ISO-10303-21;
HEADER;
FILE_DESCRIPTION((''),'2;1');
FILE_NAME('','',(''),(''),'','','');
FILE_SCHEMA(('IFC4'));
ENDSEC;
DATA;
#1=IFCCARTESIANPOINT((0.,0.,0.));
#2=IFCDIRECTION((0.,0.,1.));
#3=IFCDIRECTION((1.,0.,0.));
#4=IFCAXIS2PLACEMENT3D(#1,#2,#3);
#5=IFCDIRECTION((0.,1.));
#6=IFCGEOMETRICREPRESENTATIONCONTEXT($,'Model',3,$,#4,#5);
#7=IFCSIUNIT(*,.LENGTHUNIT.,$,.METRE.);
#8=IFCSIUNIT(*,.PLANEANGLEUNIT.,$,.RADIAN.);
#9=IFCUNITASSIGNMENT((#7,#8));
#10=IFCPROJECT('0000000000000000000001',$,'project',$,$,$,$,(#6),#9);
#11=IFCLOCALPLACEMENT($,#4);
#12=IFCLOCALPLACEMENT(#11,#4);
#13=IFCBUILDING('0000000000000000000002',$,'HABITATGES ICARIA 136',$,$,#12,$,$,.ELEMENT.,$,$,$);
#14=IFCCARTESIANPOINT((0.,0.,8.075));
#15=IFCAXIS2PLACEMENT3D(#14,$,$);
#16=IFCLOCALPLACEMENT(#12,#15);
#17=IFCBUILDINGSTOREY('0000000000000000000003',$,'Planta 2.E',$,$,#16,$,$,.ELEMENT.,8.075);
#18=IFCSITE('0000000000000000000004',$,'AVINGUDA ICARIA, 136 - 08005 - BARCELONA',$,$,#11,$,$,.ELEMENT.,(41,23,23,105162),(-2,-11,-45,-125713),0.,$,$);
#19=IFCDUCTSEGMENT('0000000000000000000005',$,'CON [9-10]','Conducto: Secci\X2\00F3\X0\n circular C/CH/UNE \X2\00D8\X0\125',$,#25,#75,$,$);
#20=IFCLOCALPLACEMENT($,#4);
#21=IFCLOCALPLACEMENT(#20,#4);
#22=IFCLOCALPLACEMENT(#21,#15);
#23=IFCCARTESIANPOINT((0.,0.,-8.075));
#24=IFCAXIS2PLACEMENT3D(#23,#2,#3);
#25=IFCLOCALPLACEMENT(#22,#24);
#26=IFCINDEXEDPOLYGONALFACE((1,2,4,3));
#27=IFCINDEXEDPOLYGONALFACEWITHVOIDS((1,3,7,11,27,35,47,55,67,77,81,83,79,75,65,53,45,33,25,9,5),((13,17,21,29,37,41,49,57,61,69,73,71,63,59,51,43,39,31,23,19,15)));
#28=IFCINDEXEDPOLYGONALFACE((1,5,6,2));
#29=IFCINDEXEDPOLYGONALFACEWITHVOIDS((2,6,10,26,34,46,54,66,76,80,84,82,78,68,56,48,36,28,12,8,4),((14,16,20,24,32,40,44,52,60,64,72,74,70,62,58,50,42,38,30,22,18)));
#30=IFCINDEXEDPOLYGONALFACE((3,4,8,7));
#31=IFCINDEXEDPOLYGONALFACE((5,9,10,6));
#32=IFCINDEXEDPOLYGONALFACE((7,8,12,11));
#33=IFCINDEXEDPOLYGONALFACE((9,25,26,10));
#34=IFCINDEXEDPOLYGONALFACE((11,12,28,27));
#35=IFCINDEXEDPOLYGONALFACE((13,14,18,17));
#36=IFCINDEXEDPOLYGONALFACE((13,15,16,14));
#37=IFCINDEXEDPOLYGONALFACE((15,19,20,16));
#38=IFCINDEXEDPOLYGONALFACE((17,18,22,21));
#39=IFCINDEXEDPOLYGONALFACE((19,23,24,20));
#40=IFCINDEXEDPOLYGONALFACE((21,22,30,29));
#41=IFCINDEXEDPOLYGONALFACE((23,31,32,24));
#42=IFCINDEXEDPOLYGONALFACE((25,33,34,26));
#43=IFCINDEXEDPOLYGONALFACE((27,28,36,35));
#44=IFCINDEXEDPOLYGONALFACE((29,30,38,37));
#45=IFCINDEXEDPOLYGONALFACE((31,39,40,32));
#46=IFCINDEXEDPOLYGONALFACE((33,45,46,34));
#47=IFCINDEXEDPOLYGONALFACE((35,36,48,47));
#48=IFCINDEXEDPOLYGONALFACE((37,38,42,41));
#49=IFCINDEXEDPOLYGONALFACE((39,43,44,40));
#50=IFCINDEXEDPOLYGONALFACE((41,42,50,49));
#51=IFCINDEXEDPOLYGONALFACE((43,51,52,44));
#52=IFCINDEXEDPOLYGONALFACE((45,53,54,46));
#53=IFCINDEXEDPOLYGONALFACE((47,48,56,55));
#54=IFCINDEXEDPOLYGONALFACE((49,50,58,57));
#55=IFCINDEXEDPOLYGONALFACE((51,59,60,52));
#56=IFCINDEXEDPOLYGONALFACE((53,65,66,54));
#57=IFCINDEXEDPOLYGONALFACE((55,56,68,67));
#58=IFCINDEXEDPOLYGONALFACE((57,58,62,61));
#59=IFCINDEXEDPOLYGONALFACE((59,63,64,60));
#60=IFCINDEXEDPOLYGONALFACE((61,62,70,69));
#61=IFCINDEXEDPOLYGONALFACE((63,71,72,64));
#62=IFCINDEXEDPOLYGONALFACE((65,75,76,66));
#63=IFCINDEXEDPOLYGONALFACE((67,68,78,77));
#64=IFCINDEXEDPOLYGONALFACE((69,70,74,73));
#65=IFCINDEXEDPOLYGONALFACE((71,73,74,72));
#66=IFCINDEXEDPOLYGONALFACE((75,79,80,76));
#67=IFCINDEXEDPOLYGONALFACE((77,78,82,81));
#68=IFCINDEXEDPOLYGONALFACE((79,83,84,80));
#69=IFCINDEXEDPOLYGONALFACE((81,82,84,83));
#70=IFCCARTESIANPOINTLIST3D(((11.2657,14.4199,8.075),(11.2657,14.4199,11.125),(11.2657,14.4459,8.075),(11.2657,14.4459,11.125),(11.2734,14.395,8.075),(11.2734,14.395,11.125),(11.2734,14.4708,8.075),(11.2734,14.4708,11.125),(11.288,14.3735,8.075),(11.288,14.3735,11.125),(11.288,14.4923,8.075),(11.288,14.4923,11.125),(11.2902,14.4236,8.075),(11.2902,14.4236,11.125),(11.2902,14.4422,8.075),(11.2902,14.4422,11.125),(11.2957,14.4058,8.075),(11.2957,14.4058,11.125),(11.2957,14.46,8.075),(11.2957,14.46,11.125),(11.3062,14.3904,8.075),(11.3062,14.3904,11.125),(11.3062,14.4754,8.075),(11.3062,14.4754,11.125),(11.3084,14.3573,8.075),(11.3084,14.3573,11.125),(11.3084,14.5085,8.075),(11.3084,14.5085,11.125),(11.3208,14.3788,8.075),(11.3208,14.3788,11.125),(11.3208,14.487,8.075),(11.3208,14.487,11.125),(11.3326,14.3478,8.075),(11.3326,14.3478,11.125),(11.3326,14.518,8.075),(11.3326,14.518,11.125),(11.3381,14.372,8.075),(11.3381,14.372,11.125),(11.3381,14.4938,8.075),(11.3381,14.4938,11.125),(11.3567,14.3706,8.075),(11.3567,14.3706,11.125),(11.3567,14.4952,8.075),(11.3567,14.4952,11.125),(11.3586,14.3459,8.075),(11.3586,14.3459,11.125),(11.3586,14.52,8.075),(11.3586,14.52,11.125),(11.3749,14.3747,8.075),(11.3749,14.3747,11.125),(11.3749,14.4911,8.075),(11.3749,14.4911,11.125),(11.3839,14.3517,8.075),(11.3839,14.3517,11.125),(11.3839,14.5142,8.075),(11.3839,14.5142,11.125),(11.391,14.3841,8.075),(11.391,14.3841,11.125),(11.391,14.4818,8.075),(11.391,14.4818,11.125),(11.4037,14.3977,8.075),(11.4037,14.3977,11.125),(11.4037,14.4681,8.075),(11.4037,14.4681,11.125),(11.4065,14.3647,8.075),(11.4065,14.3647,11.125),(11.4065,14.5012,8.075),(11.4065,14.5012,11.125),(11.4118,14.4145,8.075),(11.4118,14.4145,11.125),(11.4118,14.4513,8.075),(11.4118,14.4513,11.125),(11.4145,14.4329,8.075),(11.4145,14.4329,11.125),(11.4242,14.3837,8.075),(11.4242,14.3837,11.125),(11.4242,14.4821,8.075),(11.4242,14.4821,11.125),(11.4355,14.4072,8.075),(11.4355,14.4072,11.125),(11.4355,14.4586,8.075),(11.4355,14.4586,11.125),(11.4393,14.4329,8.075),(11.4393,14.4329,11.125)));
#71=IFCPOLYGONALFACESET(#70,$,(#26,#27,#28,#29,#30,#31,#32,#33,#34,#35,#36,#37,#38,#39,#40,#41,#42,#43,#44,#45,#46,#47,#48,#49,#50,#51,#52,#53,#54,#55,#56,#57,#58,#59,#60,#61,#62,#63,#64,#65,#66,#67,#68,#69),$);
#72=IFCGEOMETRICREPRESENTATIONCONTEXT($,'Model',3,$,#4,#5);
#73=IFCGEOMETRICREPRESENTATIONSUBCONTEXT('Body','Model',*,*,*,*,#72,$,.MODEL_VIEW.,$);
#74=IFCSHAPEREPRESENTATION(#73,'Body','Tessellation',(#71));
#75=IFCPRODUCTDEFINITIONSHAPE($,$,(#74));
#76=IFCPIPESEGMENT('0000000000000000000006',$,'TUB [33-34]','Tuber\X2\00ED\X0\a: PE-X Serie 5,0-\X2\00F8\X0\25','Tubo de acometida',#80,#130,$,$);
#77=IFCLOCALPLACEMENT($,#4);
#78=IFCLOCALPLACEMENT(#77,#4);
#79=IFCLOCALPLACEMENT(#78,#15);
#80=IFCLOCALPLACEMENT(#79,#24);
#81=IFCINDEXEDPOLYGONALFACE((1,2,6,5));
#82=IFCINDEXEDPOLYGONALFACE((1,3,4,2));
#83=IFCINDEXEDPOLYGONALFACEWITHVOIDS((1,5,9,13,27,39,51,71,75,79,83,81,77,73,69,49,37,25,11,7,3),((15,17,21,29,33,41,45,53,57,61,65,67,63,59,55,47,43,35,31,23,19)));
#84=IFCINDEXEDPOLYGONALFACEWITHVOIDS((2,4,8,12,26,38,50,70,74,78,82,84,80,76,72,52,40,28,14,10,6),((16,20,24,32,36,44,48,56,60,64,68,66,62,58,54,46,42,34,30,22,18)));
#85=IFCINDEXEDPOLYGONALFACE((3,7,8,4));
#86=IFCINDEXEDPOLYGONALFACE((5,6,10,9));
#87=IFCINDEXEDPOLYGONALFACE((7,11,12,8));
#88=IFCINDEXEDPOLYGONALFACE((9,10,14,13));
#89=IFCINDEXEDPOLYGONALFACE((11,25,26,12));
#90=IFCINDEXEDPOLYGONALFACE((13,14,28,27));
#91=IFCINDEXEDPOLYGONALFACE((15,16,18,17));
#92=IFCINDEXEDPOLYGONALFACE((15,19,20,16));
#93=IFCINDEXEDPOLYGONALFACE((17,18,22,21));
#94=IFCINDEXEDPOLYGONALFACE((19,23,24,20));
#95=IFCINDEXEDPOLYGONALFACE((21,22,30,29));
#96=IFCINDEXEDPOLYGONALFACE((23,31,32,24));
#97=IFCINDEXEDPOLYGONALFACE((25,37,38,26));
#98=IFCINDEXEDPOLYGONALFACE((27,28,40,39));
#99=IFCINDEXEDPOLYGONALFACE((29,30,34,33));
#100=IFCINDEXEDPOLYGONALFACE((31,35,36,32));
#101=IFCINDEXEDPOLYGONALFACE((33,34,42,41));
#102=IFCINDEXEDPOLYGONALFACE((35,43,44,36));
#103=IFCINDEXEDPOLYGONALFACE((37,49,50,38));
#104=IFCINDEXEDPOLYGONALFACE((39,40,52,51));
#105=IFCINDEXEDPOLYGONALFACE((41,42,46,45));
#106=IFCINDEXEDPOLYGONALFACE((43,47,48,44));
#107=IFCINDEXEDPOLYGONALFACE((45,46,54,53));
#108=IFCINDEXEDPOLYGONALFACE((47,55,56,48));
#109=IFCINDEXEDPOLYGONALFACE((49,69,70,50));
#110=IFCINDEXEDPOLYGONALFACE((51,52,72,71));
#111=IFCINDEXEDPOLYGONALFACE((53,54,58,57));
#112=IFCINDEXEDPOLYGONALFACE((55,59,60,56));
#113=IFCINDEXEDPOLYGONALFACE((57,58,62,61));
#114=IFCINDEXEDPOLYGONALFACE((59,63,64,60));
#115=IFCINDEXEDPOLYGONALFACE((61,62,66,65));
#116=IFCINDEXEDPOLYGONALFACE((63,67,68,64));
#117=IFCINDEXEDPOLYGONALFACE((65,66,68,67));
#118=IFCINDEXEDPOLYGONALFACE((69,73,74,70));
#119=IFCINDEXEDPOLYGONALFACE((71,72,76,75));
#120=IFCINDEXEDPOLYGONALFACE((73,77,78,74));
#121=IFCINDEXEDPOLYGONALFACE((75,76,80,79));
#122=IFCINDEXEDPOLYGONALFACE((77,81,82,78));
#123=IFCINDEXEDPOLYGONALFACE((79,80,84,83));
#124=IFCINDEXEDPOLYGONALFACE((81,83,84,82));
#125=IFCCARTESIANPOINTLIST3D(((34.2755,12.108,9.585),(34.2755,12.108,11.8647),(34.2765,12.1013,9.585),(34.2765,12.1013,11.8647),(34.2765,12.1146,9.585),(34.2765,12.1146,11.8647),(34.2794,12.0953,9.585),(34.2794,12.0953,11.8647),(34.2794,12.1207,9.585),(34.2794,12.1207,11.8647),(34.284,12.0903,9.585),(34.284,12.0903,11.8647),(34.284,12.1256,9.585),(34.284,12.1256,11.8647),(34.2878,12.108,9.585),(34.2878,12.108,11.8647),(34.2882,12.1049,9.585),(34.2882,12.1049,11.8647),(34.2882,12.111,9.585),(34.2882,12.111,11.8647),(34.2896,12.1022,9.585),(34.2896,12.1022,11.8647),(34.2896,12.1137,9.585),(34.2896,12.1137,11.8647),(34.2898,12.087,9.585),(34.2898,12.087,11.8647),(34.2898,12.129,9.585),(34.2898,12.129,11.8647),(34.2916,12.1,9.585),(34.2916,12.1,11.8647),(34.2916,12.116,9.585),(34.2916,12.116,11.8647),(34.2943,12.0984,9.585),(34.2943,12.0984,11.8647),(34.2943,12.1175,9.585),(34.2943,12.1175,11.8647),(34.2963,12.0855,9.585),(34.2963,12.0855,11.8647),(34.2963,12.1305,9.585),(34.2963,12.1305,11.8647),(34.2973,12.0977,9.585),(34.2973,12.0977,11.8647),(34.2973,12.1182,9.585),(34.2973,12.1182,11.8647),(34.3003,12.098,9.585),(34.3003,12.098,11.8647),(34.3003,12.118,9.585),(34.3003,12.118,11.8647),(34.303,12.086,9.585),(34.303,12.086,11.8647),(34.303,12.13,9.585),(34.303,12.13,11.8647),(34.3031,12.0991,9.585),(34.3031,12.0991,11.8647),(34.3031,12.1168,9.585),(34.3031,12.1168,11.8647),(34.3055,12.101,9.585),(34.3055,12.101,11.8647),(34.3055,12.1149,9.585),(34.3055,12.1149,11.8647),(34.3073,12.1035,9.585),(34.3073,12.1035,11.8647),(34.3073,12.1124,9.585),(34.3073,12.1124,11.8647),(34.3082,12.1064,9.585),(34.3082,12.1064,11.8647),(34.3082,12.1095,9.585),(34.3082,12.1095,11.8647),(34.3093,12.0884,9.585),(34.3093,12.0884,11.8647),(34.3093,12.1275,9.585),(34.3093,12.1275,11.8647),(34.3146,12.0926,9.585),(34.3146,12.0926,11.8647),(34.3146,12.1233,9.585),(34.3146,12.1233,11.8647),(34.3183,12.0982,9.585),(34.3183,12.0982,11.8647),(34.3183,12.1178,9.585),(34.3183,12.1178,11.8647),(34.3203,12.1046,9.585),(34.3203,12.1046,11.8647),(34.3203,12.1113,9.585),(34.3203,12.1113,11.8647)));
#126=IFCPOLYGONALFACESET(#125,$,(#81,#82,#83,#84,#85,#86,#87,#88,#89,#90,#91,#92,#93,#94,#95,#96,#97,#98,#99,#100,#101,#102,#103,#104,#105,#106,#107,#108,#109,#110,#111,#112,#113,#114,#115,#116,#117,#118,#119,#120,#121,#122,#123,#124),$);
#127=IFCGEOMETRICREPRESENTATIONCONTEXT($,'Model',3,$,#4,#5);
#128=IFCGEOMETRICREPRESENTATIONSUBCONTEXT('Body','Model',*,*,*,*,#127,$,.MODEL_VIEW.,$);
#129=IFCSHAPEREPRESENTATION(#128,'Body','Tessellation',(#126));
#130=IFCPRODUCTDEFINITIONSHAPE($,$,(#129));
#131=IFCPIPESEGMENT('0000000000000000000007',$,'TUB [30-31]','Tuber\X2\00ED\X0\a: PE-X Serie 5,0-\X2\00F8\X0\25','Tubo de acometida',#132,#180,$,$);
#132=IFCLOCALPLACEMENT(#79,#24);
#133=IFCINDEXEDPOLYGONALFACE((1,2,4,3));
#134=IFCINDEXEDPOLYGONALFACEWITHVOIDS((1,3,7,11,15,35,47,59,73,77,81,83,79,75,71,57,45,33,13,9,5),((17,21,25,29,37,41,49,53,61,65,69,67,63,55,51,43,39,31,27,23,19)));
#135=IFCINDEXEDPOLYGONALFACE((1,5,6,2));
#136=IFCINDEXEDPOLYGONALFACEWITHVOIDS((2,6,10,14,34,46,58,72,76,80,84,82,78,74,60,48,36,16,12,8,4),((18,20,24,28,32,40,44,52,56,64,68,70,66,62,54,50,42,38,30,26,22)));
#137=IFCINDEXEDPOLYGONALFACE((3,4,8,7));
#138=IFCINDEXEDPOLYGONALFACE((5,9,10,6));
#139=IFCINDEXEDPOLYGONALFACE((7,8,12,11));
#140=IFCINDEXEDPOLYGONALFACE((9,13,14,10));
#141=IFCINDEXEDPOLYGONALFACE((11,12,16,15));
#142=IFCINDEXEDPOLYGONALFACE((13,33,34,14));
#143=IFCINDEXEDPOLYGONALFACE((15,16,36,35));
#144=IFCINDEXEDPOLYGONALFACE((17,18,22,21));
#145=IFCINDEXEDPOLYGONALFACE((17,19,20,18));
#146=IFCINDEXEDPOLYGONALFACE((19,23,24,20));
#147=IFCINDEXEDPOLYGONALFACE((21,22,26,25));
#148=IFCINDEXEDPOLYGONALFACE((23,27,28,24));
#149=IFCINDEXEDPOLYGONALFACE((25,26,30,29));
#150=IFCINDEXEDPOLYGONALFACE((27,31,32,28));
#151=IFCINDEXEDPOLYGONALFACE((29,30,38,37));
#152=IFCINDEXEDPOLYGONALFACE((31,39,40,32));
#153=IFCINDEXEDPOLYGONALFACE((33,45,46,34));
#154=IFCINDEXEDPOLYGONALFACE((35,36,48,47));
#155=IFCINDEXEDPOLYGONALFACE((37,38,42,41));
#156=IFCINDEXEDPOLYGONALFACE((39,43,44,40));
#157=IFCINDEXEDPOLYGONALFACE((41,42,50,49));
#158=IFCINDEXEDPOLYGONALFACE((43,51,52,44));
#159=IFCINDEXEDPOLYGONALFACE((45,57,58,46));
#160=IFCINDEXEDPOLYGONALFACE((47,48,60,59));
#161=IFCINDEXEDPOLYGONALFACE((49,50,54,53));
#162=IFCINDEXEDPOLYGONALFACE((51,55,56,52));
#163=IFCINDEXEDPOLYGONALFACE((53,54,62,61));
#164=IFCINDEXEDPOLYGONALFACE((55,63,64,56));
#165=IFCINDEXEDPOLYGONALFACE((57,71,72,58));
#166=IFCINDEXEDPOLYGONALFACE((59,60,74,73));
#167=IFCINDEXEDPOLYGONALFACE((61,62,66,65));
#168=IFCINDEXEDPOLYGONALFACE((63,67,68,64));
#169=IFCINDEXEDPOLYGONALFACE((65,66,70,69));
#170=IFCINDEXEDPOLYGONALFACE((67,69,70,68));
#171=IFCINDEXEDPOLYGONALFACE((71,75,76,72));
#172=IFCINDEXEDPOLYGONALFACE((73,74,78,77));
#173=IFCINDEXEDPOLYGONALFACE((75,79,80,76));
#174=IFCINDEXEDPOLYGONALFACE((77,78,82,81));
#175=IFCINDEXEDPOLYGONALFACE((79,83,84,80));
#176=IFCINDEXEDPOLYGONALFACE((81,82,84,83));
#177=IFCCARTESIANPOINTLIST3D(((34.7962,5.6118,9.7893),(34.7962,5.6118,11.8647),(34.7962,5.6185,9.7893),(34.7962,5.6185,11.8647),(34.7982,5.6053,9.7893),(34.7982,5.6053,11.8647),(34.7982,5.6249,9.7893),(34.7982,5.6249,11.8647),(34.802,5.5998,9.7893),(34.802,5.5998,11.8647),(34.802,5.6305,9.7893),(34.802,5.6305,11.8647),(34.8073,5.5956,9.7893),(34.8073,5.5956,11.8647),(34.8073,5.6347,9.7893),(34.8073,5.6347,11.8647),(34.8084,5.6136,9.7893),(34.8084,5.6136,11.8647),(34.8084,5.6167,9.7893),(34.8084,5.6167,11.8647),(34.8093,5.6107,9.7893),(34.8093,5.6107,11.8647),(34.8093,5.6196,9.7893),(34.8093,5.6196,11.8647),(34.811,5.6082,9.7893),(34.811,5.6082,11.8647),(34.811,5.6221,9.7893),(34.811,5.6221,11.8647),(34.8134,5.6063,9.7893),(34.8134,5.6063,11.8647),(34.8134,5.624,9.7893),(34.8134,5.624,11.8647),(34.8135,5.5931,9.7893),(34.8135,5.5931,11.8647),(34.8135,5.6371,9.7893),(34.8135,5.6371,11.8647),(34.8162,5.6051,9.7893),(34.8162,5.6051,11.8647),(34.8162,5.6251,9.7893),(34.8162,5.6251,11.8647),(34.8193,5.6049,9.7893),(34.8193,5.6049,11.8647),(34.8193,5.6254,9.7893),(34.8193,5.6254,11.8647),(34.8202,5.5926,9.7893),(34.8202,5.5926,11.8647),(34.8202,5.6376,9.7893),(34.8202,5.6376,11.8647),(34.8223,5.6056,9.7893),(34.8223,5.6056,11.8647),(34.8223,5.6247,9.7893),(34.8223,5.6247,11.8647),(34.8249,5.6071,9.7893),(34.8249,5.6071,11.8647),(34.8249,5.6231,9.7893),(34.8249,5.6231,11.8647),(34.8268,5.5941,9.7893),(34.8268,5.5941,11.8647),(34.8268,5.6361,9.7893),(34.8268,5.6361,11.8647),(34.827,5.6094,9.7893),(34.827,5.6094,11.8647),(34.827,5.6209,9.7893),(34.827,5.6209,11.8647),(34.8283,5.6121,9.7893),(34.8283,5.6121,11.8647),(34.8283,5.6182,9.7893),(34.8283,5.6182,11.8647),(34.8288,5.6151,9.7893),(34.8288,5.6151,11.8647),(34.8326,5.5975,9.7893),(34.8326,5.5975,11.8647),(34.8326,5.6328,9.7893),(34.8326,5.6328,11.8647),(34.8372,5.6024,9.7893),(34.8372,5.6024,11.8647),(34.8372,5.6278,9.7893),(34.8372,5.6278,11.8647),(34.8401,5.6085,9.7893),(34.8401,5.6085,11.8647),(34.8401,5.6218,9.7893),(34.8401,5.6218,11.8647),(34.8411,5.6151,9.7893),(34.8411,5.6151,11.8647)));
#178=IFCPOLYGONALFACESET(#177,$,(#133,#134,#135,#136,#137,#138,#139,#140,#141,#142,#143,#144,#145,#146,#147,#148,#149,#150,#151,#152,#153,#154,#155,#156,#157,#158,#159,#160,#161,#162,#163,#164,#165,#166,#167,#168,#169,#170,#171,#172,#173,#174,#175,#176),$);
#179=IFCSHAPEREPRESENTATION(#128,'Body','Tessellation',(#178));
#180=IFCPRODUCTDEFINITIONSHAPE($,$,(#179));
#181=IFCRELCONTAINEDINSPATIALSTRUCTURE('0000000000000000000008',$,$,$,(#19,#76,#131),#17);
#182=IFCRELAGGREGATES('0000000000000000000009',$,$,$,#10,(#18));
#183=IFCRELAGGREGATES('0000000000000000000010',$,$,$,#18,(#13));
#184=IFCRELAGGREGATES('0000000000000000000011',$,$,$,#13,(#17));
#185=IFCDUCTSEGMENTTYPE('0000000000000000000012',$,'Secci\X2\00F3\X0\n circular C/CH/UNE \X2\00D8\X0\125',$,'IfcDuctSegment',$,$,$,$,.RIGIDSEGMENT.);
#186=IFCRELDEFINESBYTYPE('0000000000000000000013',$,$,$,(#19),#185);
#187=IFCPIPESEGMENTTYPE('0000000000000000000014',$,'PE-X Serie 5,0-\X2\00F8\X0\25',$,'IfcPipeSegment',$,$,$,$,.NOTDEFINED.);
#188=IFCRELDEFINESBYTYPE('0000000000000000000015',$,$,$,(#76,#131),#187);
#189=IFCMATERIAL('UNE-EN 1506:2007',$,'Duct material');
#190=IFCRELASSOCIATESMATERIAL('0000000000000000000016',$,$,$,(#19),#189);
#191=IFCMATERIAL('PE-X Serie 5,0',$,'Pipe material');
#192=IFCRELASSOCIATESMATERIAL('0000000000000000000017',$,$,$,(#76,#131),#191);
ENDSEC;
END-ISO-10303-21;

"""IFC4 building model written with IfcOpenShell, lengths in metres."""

from ifc_helpers import new_model, si_unit, direction, frame, origin_with_axes, origin_2d_with_axis, place, context, subcontext, project, spatial, hollow_circle, extrude, material, type_object, element, save


model = new_model("IFC4")

# Units and contexts
model_context_1 = context("Model", 3, world=origin_with_axes(), true_north=direction((0.0, 1.0)))
model_context_2 = context("Model", 3, world=origin_with_axes(), true_north=direction((0.0, 1.0)))
model_context_3 = context("Model", 3, world=origin_with_axes(), true_north=direction((0.0, 1.0)))
body_context_1 = subcontext(model_context_2, "Body", "Model", "MODEL_VIEW")
body_context_2 = subcontext(model_context_3, "Body", "Model", "MODEL_VIEW")
ifc_project = project(units=[si_unit("LENGTHUNIT", "METRE"), si_unit("PLANEANGLEUNIT", "RADIAN")], contexts=[model_context_1])

# Site, building, storey
site_placement = place(None, origin_with_axes())
site = spatial("IfcSite", under=ifc_project, at=site_placement, Name="AVINGUDA ICARIA, 136 - 08005 - BARCELONA", CompositionType="ELEMENT", RefLatitude=(41, 23, 23, 105162), RefLongitude=(-2, -11, -45, -125713), RefElevation=0.0)
building_placement = place(site_placement, origin_with_axes())
building = spatial("IfcBuilding", under=site, at=building_placement, Name="HABITATGES ICARIA 136", CompositionType="ELEMENT")
storey_placement = place(building_placement, frame((0.0, 0.0, 8.075)))
storey = spatial("IfcBuildingStorey", under=building, at=storey_placement, Name="Planta 2.E", CompositionType="ELEMENT", Elevation=8.075)

# Duct segment
ifc_material_1 = material(Name="UNE-EN 1506:2007", Category="Duct material")
duct_segment_type = type_object("IfcDuctSegmentType", Name="Sección circular C/CH/UNE Ø125", ApplicableOccurrence="IfcDuctSegment", PredefinedType="RIGIDSEGMENT")
placement_1 = place(None, origin_with_axes())
placement_2 = place(placement_1, origin_with_axes())
placement_3 = place(placement_2, frame((0.0, 0.0, 8.075)))
duct_segment_placement = place(placement_3, frame((0.0, 0.0, -8.075), z_axis=(0.0, 0.0, 1.0), x_axis=(1.0, 0.0, 0.0)))
element("IfcDuctSegment", 1, at=duct_segment_placement, inside=storey, type_object=duct_segment_type, material=ifc_material_1, Name="CON [9-10]", Description="Conducto: Sección circular C/CH/UNE Ø125", context=body_context_1, shape_type="SweptSolid", body=[
    extrude(hollow_circle(Radius=0.0873, WallThickness=0.0248, at=origin_2d_with_axis()), frame((11.352, 14.4329, 11.125), z_axis=(0.0, 0.0, -1.0), x_axis=(1.0, 0.0, 0.0)), (0.0, 0.0, 1.0), 3.05),
])

# Pipe segments
ifc_material_2 = material(Name="PE-X Serie 5,0", Category="Pipe material")
pipe_segment_type = type_object("IfcPipeSegmentType", Name="PE-X Serie 5,0-ø25", ApplicableOccurrence="IfcPipeSegment", PredefinedType="NOTDEFINED")
placement_4 = place(None, origin_with_axes())
placement_5 = place(placement_4, origin_with_axes())
placement_6 = place(placement_5, frame((0.0, 0.0, 8.075)))
pipe_segment_1_placement = place(placement_6, frame((0.0, 0.0, -8.075), z_axis=(0.0, 0.0, 1.0), x_axis=(1.0, 0.0, 0.0)))
element("IfcPipeSegment", 2, at=pipe_segment_1_placement, inside=storey, type_object=pipe_segment_type, material=ifc_material_2, Name="TUB [33-34]", Description="Tubería: PE-X Serie 5,0-ø25", ObjectType="Tubo de acometida", context=body_context_2, shape_type="SweptSolid", body=[
    extrude(hollow_circle(Radius=0.0226, WallThickness=0.0123, at=origin_2d_with_axis()), frame((34.298, 12.108, 11.8647), z_axis=(0.0, 0.0, -1.0), x_axis=(-1.0, 0.0, 0.0)), (0.0, 0.0, 1.0), 2.2797),
])
pipe_segment_2_placement = place(placement_6, frame((0.0, 0.0, -8.075), z_axis=(0.0, 0.0, 1.0), x_axis=(1.0, 0.0, 0.0)))
element("IfcPipeSegment", 3, at=pipe_segment_2_placement, inside=storey, type_object=pipe_segment_type, material=ifc_material_2, Name="TUB [30-31]", Description="Tubería: PE-X Serie 5,0-ø25", ObjectType="Tubo de acometida", context=body_context_2, shape_type="SweptSolid", body=[
    extrude(hollow_circle(Radius=0.0226, WallThickness=0.0123, at=origin_2d_with_axis()), frame((34.8185, 5.6151, 9.7893), z_axis=(0.0, 0.0, 1.0), x_axis=(1.0, 0.0, 0.0)), (0.0, 0.0, 1.0), 2.0754),
])

save(model, "model.ifc")
